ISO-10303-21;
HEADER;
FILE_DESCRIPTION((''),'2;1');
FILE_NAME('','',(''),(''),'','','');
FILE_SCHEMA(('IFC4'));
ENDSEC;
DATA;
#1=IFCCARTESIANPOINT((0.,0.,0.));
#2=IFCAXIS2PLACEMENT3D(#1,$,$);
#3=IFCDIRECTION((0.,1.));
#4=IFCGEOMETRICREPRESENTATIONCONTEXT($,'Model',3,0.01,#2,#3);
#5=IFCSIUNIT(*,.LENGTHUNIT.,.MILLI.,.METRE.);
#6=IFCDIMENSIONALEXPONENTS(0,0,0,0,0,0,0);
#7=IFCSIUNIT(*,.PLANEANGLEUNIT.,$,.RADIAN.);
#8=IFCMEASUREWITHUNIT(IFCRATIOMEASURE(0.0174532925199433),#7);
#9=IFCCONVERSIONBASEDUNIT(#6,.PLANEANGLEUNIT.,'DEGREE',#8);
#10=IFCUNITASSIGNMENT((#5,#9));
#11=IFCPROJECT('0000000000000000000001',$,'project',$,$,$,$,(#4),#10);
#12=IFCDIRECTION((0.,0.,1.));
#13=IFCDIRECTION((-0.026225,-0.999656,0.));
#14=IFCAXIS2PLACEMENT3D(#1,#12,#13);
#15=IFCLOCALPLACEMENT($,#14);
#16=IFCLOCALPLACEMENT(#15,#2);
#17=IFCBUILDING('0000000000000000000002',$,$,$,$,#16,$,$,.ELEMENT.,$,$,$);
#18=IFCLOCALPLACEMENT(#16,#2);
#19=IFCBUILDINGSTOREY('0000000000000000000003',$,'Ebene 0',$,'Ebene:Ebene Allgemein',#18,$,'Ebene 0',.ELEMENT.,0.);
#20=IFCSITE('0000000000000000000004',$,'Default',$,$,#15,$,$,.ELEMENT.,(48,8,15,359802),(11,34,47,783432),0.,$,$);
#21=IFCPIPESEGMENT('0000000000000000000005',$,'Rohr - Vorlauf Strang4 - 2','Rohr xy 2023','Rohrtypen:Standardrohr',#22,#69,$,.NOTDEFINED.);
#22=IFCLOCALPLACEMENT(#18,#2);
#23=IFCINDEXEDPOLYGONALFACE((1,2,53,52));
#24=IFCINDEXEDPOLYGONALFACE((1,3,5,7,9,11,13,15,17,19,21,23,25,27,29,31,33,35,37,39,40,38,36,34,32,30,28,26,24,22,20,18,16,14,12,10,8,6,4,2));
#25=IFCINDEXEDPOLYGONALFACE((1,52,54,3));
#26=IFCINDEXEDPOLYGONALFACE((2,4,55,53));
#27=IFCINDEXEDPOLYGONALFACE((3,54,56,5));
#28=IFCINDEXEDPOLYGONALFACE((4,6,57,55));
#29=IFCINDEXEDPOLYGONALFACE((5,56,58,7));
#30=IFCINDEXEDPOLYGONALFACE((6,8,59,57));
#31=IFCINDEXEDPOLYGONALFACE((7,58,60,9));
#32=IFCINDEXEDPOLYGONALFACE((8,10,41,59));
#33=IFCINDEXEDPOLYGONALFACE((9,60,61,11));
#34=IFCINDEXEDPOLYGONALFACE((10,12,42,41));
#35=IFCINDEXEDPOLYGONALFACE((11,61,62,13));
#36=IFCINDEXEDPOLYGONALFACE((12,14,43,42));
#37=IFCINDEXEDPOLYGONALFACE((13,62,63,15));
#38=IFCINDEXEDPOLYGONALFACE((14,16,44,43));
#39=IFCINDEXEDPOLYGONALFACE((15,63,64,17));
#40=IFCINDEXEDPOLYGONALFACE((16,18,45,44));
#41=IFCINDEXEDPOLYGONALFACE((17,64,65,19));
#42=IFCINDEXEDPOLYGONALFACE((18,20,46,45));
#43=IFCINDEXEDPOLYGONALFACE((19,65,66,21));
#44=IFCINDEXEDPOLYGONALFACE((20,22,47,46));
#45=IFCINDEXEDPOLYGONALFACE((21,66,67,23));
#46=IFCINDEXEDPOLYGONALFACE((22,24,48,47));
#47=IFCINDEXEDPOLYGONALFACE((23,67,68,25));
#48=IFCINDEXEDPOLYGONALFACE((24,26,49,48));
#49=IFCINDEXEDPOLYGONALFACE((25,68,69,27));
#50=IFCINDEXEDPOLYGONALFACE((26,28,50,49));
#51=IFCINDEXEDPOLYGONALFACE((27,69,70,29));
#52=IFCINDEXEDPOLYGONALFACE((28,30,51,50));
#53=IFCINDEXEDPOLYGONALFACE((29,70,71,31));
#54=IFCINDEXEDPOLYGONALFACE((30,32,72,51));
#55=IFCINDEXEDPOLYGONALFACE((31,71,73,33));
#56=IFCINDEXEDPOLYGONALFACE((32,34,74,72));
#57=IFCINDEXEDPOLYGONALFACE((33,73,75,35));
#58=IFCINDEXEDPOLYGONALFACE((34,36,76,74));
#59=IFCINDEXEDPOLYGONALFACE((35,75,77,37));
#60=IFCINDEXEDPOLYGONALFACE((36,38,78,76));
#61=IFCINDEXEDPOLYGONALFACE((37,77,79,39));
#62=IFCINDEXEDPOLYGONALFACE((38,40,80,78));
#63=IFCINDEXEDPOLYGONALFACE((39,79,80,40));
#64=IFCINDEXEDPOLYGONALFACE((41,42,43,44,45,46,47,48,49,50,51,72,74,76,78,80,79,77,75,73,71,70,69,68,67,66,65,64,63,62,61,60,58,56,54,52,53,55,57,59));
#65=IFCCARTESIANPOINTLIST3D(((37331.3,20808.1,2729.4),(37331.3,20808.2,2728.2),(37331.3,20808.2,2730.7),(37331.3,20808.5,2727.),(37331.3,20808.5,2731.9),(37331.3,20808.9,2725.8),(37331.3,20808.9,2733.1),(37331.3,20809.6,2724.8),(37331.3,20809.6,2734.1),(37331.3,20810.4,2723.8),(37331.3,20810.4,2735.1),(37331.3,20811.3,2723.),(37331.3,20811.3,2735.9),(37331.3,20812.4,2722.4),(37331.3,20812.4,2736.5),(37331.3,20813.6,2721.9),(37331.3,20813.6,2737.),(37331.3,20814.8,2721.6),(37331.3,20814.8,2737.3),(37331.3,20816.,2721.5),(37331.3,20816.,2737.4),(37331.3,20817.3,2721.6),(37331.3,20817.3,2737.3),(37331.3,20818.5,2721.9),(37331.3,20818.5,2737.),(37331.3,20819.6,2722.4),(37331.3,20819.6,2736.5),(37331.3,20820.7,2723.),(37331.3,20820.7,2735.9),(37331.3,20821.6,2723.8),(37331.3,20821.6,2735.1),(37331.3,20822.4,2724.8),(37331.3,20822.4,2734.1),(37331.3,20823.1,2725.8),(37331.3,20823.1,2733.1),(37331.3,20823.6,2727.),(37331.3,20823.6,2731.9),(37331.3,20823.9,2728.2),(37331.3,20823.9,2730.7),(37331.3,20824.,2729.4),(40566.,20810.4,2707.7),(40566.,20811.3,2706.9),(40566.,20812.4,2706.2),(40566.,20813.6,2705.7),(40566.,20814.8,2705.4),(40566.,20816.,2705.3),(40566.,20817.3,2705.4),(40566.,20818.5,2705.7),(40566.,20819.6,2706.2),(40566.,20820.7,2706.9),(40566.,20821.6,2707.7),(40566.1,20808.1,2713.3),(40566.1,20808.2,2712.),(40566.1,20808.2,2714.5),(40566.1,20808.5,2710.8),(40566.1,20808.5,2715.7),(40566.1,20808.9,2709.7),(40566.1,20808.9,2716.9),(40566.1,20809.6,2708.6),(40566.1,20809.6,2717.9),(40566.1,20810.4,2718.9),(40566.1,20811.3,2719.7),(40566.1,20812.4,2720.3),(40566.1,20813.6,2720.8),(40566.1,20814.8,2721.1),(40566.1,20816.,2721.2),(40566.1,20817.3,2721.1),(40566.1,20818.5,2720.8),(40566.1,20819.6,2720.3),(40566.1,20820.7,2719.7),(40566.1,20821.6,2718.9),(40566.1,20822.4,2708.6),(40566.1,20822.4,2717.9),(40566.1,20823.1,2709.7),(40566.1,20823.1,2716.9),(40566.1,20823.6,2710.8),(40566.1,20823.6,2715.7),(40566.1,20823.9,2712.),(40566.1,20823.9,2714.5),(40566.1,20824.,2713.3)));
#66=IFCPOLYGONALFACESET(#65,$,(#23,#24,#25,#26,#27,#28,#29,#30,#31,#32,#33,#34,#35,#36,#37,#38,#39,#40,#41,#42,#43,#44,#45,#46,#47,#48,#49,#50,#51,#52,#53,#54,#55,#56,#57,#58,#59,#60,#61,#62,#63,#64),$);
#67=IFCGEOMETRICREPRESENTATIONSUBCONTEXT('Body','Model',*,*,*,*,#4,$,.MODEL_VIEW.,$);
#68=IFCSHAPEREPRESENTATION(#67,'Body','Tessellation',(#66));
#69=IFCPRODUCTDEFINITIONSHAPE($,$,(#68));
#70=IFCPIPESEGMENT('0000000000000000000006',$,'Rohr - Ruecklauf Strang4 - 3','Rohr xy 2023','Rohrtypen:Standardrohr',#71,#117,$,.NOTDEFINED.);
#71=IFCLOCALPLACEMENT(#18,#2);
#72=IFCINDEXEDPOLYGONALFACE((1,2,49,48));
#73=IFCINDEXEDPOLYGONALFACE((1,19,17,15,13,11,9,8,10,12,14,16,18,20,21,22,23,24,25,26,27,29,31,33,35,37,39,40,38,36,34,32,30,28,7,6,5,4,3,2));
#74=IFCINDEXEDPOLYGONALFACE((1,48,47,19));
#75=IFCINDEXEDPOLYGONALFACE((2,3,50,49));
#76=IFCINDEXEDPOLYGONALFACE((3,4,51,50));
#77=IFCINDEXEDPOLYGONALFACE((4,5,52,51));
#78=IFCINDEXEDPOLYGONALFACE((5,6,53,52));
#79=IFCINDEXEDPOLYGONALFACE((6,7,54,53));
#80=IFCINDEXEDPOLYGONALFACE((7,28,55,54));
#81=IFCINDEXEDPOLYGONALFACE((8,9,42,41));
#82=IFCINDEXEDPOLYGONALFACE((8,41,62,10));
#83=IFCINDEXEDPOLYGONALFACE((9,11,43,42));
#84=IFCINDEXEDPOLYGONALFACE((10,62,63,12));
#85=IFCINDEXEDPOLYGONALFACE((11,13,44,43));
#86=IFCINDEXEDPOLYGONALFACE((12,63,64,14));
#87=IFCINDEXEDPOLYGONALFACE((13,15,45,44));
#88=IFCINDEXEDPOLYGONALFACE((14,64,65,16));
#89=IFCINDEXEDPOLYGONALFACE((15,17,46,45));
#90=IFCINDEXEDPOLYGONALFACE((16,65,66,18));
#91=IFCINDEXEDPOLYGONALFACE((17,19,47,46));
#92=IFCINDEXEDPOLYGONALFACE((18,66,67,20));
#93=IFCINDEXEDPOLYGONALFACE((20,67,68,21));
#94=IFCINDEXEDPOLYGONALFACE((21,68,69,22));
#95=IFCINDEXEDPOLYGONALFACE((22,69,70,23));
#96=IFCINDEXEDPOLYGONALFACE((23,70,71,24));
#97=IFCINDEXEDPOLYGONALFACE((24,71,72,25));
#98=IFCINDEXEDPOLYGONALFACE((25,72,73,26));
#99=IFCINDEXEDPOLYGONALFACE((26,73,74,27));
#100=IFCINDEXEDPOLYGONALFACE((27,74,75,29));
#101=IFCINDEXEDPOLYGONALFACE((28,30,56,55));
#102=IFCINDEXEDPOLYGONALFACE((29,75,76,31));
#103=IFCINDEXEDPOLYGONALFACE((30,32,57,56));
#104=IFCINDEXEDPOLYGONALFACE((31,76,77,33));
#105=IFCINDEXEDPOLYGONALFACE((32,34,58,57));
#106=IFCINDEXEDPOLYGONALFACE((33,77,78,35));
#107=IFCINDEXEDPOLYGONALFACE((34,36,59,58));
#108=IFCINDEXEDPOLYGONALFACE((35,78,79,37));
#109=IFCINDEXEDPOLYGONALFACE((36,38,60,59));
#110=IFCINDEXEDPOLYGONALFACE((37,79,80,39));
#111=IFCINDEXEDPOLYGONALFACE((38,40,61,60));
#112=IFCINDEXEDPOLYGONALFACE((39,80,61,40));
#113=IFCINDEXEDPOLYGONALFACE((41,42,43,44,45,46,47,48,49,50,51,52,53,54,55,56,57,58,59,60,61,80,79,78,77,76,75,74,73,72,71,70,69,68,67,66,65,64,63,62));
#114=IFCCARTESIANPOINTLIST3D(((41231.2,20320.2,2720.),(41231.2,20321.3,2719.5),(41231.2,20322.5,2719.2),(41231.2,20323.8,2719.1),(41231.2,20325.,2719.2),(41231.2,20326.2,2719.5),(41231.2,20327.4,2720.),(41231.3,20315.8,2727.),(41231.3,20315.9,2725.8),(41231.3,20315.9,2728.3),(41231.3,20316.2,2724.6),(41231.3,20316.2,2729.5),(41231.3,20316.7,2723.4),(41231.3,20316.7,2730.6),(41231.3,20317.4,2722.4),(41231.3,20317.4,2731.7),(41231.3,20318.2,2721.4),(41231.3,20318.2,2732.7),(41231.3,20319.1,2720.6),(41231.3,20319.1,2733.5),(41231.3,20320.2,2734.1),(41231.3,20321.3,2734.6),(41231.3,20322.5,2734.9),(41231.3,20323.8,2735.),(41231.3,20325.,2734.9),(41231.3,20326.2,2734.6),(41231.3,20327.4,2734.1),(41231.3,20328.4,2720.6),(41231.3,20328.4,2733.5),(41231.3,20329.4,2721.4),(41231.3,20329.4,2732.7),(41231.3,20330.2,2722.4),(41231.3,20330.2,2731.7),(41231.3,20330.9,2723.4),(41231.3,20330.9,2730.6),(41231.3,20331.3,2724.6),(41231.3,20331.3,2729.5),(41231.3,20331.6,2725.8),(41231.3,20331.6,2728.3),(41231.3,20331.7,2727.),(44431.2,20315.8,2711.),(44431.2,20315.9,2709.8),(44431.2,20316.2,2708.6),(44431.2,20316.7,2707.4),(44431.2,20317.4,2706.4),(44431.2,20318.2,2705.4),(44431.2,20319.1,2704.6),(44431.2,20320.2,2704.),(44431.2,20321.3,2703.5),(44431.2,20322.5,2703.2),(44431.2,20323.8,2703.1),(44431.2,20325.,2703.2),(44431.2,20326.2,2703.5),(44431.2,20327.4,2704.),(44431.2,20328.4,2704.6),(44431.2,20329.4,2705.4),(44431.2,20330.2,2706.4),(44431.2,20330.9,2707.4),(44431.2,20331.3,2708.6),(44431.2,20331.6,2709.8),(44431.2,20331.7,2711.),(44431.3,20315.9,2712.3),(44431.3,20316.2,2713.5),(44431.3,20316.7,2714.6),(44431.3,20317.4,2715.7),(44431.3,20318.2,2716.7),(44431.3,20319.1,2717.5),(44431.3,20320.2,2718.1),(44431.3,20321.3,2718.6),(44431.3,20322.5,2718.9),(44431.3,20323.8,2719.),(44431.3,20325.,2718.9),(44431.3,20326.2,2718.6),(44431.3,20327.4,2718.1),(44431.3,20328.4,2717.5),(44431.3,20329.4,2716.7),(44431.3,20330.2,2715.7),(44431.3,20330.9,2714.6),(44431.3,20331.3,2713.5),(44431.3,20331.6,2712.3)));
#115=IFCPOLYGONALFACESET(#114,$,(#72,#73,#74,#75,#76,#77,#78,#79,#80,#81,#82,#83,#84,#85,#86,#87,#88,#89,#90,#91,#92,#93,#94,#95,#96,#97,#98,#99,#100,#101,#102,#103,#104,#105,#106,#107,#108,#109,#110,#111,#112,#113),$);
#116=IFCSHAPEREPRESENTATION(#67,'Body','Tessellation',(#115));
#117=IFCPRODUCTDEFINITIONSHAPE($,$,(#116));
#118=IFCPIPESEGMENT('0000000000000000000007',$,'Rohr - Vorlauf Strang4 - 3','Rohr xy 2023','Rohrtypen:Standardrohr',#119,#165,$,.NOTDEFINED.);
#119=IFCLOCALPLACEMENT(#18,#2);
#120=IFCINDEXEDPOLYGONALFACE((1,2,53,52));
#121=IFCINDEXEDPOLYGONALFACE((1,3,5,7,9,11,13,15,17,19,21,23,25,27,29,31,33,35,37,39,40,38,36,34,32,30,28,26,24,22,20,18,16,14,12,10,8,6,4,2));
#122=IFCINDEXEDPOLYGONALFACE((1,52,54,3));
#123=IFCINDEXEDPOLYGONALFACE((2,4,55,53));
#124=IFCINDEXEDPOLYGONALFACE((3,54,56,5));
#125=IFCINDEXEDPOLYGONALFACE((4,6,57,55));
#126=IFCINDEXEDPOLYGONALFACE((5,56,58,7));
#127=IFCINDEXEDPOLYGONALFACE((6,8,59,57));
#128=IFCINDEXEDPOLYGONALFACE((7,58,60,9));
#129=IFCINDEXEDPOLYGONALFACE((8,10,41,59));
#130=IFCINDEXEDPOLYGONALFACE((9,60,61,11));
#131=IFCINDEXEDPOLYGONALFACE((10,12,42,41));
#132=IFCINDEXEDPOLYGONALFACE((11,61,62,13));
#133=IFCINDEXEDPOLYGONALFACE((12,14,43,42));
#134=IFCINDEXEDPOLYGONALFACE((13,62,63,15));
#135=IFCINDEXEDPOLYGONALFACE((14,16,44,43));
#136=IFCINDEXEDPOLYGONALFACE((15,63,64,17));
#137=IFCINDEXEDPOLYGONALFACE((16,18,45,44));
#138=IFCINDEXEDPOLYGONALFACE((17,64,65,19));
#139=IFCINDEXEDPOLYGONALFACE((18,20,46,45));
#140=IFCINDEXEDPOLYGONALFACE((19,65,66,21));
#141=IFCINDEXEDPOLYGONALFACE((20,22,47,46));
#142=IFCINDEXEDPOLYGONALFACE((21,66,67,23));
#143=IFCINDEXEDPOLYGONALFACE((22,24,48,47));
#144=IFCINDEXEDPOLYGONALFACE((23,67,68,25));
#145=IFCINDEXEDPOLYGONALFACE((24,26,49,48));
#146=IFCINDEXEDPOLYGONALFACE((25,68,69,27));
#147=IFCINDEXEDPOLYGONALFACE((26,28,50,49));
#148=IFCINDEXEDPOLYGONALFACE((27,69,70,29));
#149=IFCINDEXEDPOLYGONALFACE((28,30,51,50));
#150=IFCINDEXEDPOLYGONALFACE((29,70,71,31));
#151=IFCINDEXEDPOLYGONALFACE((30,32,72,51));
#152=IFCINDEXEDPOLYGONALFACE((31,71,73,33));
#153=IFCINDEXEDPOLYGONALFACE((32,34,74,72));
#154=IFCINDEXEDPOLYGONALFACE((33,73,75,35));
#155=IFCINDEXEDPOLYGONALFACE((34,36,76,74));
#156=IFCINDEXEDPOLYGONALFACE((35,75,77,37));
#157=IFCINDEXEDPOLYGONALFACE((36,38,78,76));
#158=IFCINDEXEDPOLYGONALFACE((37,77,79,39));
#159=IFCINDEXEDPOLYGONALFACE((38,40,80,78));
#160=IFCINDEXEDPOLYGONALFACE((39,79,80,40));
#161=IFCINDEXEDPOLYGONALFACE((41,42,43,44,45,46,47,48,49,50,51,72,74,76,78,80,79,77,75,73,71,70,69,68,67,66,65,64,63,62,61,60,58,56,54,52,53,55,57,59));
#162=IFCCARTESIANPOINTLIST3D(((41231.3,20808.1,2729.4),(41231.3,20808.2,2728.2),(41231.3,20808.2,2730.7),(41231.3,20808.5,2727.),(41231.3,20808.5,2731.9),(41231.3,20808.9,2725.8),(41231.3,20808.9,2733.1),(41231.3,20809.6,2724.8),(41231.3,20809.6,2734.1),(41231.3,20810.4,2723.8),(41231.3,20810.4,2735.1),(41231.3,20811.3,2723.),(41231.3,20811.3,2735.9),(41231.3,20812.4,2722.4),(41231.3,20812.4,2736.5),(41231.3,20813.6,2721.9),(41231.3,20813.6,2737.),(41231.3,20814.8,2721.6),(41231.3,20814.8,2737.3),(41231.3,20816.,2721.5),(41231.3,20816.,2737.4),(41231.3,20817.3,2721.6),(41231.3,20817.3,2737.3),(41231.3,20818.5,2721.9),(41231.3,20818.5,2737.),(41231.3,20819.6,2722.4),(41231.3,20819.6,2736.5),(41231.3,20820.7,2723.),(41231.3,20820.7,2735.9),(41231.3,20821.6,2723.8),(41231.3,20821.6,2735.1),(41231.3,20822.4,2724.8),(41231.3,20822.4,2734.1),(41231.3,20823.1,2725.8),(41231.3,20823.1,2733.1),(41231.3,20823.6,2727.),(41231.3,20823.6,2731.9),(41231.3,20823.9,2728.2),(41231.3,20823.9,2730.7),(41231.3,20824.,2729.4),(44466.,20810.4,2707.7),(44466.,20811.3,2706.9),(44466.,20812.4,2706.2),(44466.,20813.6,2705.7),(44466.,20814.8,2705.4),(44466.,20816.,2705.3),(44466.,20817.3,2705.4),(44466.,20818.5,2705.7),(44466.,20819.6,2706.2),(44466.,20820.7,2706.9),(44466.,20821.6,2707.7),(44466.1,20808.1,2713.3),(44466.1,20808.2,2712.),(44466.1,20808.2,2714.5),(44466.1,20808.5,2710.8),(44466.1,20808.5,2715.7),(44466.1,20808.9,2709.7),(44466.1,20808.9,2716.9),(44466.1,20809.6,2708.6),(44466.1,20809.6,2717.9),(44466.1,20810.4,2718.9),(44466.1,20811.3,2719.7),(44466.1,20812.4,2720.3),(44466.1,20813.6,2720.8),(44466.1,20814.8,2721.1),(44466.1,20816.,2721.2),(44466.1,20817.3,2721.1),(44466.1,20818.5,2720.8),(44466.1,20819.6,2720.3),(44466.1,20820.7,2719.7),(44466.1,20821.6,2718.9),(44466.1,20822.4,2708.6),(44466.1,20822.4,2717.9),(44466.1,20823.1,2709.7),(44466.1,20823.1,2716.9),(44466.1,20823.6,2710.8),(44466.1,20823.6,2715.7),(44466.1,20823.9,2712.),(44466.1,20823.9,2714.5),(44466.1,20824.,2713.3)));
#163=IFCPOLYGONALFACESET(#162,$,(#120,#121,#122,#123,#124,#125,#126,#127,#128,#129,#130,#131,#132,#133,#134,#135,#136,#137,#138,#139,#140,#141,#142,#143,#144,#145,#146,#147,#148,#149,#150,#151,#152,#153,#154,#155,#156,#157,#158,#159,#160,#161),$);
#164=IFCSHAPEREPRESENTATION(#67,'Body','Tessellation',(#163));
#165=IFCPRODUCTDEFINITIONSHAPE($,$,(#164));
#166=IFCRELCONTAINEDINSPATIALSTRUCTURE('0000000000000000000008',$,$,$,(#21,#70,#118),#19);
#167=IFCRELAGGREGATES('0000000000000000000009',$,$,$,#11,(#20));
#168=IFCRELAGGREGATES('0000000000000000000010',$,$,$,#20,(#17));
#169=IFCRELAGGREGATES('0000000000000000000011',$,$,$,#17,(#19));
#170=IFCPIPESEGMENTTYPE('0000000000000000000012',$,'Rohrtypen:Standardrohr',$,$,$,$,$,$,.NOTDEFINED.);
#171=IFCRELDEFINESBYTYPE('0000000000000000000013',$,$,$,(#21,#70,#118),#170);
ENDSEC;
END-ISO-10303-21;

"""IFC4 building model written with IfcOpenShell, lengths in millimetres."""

from ifc_helpers import new_model, entity, si_unit, converted_unit, direction, frame, origin, place, context, subcontext, project, spatial, indexed_curve, outline, extrude, type_object, element, save


model = new_model("IFC4")

# Units and contexts
model_context = context("Model", 3, precision=0.01, world=origin(), true_north=direction((0.0, 1.0)))
body_context = subcontext(model_context, "Body", "Model", "MODEL_VIEW")
ifc_project = project(units=[si_unit("LENGTHUNIT", "METRE", prefix="MILLI"), converted_unit("PLANEANGLEUNIT", "DEGREE", entity("IfcRatioMeasure", 0.0174532925199433), si_unit("PLANEANGLEUNIT", "RADIAN"), dimensions=[0, 0, 0, 0, 0, 0, 0])], contexts=[model_context])

# Site, building, storey
site_placement = place(None, frame((0.0, 0.0, 0.0), z_axis=(0.0, 0.0, 1.0), x_axis=(-0.026225, -0.999656, 0.0)))
site = spatial("IfcSite", under=ifc_project, at=site_placement, Name="Default", CompositionType="ELEMENT", RefLatitude=(48, 8, 15, 359802), RefLongitude=(11, 34, 47, 783432), RefElevation=0.0)
building_placement = place(site_placement, origin())
building = spatial("IfcBuilding", under=site, at=building_placement, CompositionType="ELEMENT")
storey_placement = place(building_placement, origin())
storey = spatial("IfcBuildingStorey", under=building, at=storey_placement, Name="Ebene 0", ObjectType="Ebene:Ebene Allgemein", LongName="Ebene 0", CompositionType="ELEMENT", Elevation=0.0)

# Pipe segments
pipe_segment_type = type_object("IfcPipeSegmentType", Name="Rohrtypen:Standardrohr", PredefinedType="NOTDEFINED")
pipe_segment_1_placement = place(storey_placement, origin())
element("IfcPipeSegment", 1, at=pipe_segment_1_placement, inside=storey, type_object=pipe_segment_type, Name="Rohr - Vorlauf Strang4 - 2", Description="Rohr xy 2023", ObjectType="Rohrtypen:Standardrohr", PredefinedType="NOTDEFINED", context=body_context, shape_type="SweptSolid", body=[
    extrude(outline(indexed_curve([(7.9, 0.0), (7.8, 1.2), (7.6, 2.5), (7.1, 3.6), (6.4, 4.7), (5.6, 5.6), (4.7, 6.4), (3.6, 7.1), (2.5, 7.6), (1.2, 7.8), (0.0, 7.9), (-1.2, 7.8), (-2.5, 7.6), (-3.6, 7.1), (-4.7, 6.4), (-5.6, 5.6), (-6.4, 4.7), (-7.1, 3.6), (-7.6, 2.5), (-7.8, 1.2), (-7.9, 0.0), (-7.8, -1.2), (-7.6, -2.5), (-7.1, -3.6), (-6.4, -4.7), (-5.6, -5.6), (-4.7, -6.4), (-3.6, -7.1), (-2.5, -7.6), (-1.2, -7.8), (0.0, -7.9), (1.2, -7.8), (2.5, -7.6), (3.6, -7.1), (4.7, -6.4), (5.6, -5.6), (6.4, -4.7), (7.1, -3.6), (7.6, -2.5), (7.8, -1.2), (7.9, 0.0)], self_intersect=False)), frame((40566.1, 20816.0, 2713.3), z_axis=(-0.999988, 0.0, 0.005), x_axis=(0.0, 1.0, 0.0)), (0.0, 0.0, 1.0), 3234.8),
])
pipe_segment_2_placement = place(storey_placement, origin())
element("IfcPipeSegment", 2, at=pipe_segment_2_placement, inside=storey, type_object=pipe_segment_type, Name="Rohr - Ruecklauf Strang4 - 3", Description="Rohr xy 2023", ObjectType="Rohrtypen:Standardrohr", PredefinedType="NOTDEFINED", context=body_context, shape_type="SweptSolid", body=[
    extrude(outline(indexed_curve([(7.9, 0.0), (7.8, 1.2), (7.6, 2.5), (7.1, 3.6), (6.4, 4.7), (5.6, 5.6), (4.7, 6.4), (3.6, 7.1), (2.5, 7.6), (1.2, 7.8), (0.0, 7.9), (-1.2, 7.8), (-2.5, 7.6), (-3.6, 7.1), (-4.7, 6.4), (-5.6, 5.6), (-6.4, 4.7), (-7.1, 3.6), (-7.6, 2.5), (-7.8, 1.2), (-7.9, 0.0), (-7.8, -1.2), (-7.6, -2.5), (-7.1, -3.6), (-6.4, -4.7), (-5.6, -5.6), (-4.7, -6.4), (-3.6, -7.1), (-2.5, -7.6), (-1.2, -7.8), (0.0, -7.9), (1.2, -7.8), (2.5, -7.6), (3.6, -7.1), (4.7, -6.4), (5.6, -5.6), (6.4, -4.7), (7.1, -3.6), (7.6, -2.5), (7.8, -1.2), (7.9, 0.0)], self_intersect=False)), frame((44431.2, 20323.8, 2711.0), z_axis=(-0.999988, 0.0, 0.005), x_axis=(0.0, 1.0, 0.0)), (0.0, 0.0, 1.0), 3200.0),
])
pipe_segment_3_placement = place(storey_placement, origin())
element("IfcPipeSegment", 3, at=pipe_segment_3_placement, inside=storey, type_object=pipe_segment_type, Name="Rohr - Vorlauf Strang4 - 3", Description="Rohr xy 2023", ObjectType="Rohrtypen:Standardrohr", PredefinedType="NOTDEFINED", context=body_context, shape_type="SweptSolid", body=[
    extrude(outline(indexed_curve([(7.9, 0.0), (7.8, 1.2), (7.6, 2.5), (7.1, 3.6), (6.4, 4.7), (5.6, 5.6), (4.7, 6.4), (3.6, 7.1), (2.5, 7.6), (1.2, 7.8), (0.0, 7.9), (-1.2, 7.8), (-2.5, 7.6), (-3.6, 7.1), (-4.7, 6.4), (-5.6, 5.6), (-6.4, 4.7), (-7.1, 3.6), (-7.6, 2.5), (-7.8, 1.2), (-7.9, 0.0), (-7.8, -1.2), (-7.6, -2.5), (-7.1, -3.6), (-6.4, -4.7), (-5.6, -5.6), (-4.7, -6.4), (-3.6, -7.1), (-2.5, -7.6), (-1.2, -7.8), (0.0, -7.9), (1.2, -7.8), (2.5, -7.6), (3.6, -7.1), (4.7, -6.4), (5.6, -5.6), (6.4, -4.7), (7.1, -3.6), (7.6, -2.5), (7.8, -1.2), (7.9, 0.0)], self_intersect=False)), frame((44466.1, 20816.0, 2713.3), z_axis=(-0.999988, 0.0, 0.005), x_axis=(0.0, 1.0, 0.0)), (0.0, 0.0, 1.0), 3234.8),
])

save(model, "model.ifc")
